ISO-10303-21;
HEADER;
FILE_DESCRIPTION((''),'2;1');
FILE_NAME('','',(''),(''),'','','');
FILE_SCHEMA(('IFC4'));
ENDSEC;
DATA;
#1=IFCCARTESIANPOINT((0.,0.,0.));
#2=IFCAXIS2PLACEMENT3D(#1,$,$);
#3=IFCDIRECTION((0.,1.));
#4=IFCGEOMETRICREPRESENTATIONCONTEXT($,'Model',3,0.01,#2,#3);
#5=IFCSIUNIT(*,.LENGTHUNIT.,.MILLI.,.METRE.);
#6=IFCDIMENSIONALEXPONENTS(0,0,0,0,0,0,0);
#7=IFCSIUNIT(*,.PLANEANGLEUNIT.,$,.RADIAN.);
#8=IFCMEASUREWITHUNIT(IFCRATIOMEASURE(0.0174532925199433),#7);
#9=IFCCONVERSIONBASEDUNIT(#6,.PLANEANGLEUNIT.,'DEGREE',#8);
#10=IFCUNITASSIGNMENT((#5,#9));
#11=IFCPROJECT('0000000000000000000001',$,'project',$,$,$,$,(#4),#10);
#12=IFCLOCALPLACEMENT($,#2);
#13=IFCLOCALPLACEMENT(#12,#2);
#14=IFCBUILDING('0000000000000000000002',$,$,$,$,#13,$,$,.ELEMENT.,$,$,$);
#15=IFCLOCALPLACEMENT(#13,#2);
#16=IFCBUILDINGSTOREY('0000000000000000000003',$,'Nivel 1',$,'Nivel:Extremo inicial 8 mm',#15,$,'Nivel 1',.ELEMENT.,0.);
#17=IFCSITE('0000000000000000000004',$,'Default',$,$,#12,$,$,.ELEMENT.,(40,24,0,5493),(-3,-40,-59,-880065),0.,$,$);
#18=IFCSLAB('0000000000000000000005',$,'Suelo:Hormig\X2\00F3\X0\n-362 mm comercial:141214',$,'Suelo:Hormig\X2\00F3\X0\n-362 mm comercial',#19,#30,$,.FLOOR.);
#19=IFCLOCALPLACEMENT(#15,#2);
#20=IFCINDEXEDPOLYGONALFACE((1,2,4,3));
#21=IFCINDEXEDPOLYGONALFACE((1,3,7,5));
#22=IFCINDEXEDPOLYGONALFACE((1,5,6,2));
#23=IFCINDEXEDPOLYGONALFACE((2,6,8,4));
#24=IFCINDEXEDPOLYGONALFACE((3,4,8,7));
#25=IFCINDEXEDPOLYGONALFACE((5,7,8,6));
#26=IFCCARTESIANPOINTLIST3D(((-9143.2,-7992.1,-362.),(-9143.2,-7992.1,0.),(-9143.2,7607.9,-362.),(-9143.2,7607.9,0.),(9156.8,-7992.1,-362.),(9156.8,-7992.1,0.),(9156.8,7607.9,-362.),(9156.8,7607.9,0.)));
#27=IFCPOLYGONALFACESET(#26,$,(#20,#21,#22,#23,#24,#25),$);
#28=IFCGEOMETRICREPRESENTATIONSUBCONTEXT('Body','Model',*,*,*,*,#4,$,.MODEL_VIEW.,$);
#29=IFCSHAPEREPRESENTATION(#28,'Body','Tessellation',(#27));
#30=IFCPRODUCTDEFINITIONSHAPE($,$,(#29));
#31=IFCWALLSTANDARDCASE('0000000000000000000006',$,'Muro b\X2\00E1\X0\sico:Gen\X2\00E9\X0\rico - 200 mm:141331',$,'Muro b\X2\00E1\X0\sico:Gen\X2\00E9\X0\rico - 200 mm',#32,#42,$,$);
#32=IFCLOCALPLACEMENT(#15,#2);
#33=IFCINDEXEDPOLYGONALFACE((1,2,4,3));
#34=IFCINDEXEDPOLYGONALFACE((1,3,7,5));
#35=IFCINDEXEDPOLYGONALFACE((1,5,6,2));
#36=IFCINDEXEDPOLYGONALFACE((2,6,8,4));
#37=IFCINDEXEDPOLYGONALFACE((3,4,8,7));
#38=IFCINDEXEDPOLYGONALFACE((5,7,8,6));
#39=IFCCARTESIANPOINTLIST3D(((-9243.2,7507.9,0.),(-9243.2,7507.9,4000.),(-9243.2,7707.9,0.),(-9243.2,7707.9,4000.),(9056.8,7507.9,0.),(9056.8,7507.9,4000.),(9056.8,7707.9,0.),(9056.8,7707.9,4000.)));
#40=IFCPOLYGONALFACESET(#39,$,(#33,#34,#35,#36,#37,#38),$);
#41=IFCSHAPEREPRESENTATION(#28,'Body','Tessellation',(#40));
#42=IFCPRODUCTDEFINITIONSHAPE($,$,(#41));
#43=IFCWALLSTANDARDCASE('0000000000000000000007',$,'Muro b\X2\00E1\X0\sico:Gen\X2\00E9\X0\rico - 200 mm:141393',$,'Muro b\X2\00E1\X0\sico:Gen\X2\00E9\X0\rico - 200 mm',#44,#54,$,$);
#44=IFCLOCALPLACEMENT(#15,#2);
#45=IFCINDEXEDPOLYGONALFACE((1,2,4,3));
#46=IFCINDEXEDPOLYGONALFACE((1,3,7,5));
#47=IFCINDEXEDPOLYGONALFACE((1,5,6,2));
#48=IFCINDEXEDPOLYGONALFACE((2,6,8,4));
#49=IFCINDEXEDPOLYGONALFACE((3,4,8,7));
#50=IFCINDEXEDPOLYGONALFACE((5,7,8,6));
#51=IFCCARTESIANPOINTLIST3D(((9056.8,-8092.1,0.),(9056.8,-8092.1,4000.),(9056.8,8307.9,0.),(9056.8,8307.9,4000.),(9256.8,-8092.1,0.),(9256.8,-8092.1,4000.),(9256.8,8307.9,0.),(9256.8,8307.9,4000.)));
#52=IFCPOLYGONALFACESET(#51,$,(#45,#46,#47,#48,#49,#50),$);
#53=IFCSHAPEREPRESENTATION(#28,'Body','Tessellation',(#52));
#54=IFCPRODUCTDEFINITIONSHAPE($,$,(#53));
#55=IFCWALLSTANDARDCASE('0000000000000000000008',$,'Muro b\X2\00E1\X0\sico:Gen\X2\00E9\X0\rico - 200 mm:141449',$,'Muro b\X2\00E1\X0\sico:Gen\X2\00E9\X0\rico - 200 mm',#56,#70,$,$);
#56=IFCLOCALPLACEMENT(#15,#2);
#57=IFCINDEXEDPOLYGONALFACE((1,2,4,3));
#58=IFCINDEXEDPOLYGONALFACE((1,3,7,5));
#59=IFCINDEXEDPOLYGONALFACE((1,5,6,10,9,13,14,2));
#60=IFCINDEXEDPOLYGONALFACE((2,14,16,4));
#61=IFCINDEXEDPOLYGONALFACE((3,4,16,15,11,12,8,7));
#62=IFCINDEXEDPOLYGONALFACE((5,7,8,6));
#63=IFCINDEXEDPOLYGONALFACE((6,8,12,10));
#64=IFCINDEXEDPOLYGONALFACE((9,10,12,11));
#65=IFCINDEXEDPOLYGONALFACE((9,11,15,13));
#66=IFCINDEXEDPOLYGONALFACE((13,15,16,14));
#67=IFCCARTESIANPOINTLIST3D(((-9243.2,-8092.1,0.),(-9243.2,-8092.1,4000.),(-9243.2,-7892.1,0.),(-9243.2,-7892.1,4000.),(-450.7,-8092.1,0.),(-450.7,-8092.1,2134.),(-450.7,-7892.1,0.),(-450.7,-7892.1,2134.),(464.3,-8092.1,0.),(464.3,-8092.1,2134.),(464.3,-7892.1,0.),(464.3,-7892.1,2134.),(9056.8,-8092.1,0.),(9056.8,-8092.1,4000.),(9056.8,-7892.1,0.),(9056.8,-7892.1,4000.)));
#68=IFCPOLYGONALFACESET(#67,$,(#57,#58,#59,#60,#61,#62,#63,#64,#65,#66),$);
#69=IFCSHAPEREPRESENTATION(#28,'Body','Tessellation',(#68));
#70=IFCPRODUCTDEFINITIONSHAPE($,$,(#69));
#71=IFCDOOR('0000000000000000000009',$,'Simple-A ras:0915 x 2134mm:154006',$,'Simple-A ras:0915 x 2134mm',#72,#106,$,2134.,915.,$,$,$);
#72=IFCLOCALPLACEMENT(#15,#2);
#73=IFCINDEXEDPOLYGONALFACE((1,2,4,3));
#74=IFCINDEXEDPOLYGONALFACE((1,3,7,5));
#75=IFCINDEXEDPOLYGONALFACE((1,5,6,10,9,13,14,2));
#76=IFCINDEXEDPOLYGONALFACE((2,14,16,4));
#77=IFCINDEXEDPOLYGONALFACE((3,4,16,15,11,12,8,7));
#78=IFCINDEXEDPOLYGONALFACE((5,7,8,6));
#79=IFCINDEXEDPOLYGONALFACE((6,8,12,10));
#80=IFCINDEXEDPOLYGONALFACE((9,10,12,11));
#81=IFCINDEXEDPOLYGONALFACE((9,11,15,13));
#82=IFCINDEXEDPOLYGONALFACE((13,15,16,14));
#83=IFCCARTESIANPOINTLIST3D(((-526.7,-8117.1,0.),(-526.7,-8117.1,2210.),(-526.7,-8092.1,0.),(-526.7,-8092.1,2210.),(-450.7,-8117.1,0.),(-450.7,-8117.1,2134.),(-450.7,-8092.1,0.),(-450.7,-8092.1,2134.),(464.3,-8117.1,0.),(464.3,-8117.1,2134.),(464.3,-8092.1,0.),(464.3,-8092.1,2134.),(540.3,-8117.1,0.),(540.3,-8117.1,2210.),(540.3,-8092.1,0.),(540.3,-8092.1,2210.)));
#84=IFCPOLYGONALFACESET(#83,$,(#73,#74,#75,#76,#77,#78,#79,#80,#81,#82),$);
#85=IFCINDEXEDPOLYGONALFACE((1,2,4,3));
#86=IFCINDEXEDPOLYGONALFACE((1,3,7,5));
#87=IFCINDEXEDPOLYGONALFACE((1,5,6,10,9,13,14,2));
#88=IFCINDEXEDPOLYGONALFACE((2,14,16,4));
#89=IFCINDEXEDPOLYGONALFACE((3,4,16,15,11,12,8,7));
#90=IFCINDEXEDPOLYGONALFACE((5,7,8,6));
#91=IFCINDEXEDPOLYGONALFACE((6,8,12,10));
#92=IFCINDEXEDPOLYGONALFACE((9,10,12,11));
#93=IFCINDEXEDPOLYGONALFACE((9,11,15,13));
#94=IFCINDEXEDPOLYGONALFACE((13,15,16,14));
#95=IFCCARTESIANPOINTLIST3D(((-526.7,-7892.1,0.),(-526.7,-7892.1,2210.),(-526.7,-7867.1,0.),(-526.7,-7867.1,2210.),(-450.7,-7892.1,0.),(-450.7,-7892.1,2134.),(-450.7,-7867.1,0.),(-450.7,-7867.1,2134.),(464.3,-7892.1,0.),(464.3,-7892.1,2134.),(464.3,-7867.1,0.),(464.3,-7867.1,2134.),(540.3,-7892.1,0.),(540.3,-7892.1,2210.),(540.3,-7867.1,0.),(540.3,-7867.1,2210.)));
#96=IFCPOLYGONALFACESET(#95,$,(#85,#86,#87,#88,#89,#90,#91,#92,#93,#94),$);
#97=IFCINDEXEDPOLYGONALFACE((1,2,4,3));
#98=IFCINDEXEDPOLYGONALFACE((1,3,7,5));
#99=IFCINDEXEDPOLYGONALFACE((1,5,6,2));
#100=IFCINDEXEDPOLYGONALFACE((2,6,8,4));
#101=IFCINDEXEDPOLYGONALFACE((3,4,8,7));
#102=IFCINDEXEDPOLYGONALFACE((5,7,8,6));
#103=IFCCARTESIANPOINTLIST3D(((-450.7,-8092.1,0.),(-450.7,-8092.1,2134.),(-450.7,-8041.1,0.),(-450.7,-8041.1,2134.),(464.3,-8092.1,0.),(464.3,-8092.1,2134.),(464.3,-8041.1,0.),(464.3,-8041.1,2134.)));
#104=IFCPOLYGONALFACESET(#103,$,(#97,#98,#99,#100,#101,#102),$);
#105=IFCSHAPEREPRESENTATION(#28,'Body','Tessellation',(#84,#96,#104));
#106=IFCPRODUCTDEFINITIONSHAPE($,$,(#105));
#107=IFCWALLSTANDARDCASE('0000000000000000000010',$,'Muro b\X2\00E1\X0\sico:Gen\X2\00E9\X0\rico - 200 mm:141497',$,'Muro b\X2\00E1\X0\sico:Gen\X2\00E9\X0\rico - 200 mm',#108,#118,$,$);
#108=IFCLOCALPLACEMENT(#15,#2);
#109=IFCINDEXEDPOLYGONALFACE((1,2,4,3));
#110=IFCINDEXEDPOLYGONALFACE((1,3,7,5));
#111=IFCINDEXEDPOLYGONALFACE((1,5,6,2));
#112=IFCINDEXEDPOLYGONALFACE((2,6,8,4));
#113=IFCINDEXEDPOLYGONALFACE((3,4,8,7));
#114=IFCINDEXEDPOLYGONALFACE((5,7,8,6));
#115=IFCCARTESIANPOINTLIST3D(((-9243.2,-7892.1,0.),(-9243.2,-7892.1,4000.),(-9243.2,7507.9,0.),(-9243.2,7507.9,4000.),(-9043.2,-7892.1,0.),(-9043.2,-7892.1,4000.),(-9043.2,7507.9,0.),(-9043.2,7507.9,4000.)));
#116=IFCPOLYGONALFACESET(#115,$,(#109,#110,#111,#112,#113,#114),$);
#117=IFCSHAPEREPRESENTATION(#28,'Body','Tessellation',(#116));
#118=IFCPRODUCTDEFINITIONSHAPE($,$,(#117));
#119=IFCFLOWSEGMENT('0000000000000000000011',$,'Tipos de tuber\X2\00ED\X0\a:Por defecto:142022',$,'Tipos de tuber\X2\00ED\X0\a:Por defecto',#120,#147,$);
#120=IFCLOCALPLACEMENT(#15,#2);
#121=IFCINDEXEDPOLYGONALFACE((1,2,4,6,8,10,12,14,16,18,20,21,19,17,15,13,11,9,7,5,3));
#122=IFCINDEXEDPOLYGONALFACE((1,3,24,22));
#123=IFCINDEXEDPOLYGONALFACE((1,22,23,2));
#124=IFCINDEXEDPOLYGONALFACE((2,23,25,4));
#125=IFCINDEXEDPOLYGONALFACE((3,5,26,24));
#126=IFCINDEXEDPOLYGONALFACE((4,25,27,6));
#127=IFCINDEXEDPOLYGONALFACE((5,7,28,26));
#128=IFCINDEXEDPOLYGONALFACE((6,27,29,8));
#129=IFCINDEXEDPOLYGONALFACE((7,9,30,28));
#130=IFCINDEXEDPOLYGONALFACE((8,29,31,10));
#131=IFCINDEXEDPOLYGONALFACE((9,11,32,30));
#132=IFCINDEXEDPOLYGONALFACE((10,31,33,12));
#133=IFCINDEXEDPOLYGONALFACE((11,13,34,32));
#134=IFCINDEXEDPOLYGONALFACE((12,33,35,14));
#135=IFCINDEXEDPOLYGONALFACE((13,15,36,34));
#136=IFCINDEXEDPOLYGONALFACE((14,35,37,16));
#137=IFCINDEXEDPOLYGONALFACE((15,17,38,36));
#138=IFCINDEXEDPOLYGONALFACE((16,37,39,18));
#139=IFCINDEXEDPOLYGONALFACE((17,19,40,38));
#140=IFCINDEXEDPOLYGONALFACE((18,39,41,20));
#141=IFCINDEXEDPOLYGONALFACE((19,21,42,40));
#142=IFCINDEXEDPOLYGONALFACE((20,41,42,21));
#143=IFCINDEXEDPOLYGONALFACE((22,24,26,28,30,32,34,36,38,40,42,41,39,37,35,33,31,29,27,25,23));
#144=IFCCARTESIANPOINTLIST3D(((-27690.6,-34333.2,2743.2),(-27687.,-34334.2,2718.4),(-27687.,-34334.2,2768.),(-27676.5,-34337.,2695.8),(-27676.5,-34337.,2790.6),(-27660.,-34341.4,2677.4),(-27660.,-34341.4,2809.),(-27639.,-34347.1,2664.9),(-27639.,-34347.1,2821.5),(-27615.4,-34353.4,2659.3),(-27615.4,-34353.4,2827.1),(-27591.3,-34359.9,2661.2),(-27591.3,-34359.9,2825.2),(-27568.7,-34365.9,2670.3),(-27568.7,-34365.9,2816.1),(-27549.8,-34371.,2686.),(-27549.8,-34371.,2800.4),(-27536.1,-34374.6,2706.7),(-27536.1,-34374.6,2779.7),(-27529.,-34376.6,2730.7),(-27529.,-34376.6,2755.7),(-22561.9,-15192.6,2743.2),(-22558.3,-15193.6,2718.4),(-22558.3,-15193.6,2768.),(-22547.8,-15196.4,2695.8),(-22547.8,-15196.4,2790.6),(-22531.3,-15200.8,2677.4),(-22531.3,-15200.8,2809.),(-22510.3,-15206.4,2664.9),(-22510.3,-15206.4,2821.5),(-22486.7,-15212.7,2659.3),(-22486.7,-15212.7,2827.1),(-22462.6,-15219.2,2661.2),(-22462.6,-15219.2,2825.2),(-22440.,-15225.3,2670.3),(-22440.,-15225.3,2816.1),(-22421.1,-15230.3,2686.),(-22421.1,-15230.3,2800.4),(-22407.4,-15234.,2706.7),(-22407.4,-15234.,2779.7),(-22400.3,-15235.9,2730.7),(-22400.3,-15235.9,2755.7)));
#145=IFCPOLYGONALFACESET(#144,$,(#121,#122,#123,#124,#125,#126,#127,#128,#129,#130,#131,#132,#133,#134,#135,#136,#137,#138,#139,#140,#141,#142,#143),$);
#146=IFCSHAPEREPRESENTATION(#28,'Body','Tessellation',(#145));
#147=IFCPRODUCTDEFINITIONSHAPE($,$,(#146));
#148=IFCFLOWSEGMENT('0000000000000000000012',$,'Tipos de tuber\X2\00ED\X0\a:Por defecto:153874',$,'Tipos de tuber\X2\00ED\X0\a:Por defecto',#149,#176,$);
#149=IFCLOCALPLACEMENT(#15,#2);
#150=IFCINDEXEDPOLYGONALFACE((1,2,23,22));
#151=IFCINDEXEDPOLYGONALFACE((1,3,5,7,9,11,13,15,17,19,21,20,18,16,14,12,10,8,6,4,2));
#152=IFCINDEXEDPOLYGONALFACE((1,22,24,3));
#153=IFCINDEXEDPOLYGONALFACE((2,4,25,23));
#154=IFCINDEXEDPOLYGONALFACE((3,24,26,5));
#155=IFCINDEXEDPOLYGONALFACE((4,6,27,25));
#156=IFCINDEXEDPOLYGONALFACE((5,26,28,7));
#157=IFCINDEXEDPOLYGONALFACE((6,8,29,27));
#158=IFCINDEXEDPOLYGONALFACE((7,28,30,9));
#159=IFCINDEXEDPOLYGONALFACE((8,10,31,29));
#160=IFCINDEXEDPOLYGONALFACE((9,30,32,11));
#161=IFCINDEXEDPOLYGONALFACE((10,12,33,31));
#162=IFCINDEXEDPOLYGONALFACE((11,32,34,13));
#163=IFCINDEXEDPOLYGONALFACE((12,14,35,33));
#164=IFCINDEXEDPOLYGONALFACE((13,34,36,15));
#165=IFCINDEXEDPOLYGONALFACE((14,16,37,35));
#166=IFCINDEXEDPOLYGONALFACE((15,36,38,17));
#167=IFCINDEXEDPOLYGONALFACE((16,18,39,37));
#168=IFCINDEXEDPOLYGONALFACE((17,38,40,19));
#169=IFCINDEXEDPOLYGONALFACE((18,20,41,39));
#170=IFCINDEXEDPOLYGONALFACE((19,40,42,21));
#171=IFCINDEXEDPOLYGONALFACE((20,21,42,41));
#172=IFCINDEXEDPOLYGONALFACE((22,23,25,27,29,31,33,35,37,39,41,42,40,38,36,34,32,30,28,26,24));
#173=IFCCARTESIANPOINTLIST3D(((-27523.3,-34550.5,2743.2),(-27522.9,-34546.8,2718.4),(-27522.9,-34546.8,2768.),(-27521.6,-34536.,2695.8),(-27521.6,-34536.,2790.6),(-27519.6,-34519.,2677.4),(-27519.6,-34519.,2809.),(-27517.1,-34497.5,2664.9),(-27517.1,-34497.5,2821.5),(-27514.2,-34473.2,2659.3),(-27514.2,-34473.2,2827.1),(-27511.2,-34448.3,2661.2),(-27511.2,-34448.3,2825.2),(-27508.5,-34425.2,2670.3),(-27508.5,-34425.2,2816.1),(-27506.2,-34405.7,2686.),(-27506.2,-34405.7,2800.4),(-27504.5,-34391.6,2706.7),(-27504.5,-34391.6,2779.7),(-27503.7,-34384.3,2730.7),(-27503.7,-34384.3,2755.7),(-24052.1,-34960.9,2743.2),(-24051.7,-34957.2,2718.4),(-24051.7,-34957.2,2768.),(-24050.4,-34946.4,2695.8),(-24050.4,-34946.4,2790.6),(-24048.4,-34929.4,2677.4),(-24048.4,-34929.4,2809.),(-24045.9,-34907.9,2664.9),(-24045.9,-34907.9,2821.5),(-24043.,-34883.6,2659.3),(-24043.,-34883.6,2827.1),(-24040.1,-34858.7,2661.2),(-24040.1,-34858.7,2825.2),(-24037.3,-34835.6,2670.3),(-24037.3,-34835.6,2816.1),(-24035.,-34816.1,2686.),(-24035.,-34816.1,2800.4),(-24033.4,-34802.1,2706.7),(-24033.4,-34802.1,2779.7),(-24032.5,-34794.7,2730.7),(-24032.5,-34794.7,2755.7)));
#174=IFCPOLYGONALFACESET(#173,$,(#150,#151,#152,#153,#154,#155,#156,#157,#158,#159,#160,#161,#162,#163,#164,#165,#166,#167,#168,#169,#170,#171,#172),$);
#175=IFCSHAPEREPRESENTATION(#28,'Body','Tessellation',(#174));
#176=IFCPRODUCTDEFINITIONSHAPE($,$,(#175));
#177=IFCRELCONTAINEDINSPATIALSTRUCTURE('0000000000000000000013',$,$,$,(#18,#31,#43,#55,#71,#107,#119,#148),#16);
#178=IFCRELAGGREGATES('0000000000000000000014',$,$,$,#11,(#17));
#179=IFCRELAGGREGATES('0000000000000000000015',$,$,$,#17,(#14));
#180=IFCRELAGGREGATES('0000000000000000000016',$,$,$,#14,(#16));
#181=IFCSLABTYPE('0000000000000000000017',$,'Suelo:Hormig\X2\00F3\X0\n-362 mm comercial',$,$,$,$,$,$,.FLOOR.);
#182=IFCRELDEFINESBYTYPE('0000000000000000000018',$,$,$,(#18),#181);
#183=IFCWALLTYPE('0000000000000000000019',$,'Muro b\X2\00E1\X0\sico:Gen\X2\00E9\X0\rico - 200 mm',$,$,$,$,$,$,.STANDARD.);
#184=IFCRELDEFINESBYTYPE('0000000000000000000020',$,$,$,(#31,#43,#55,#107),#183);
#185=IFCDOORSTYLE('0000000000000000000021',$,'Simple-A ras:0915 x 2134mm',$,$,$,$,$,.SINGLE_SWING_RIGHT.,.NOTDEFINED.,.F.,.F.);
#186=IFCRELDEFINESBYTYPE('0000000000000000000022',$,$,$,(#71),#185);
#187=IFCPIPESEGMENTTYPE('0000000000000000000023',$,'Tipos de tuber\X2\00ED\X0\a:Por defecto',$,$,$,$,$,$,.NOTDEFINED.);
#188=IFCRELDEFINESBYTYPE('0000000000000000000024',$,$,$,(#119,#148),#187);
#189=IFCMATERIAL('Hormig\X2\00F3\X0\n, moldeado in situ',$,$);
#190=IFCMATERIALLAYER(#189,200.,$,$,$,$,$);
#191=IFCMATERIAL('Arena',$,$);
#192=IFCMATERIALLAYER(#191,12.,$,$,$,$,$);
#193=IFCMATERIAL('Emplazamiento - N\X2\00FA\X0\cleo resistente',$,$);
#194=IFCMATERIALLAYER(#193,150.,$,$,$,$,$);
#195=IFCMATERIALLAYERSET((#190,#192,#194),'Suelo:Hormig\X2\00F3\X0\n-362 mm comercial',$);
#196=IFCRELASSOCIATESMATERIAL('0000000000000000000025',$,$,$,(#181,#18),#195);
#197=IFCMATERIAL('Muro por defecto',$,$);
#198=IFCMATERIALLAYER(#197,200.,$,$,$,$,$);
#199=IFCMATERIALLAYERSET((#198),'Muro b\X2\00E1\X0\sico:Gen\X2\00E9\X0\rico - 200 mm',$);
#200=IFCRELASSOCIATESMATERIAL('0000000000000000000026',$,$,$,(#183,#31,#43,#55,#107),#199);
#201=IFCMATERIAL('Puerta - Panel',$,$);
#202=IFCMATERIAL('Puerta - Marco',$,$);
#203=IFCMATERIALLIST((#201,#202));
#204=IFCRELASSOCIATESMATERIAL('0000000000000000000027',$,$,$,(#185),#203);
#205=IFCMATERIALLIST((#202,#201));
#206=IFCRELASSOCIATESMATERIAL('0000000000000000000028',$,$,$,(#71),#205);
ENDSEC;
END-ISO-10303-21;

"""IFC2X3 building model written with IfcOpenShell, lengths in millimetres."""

from ifc_helpers import new_model, entity, si_unit, converted_unit, direction, frame, frame_2d, origin, origin_2d_with_axis, place, context, subcontext, project, spatial, polyline, rectangle, circle, outline, extrude, source, transform, mapped, material, material_list, layer, layer_set, layer_usage, type_object, type_shapes, element, fill, save


model = new_model("IFC2X3")

# Units and contexts
model_context = context("Model", 3, precision=0.01, world=origin(), true_north=direction((0.0, 1.0)))
body_context = subcontext(model_context, "Body", "Model", "MODEL_VIEW")
ifc_project = project(units=[si_unit("LENGTHUNIT", "METRE", prefix="MILLI"), converted_unit("PLANEANGLEUNIT", "DEGREE", entity("IfcRatioMeasure", 0.0174532925199433), si_unit("PLANEANGLEUNIT", "RADIAN"), dimensions=[0, 0, 0, 0, 0, 0, 0])], contexts=[model_context])

# Site, building, storey
site_placement = place(None, origin())
site = spatial("IfcSite", under=ifc_project, at=site_placement, Name="Default", CompositionType="ELEMENT", RefLatitude=(40, 24, 0, 5493), RefLongitude=(-3, -40, -59, -880065), RefElevation=0.0)
building_placement = place(site_placement, origin())
building = spatial("IfcBuilding", under=site, at=building_placement, CompositionType="ELEMENT")
storey_placement = place(building_placement, origin())
storey = spatial("IfcBuildingStorey", under=building, at=storey_placement, Name="Nivel 1", ObjectType="Nivel:Extremo inicial 8 mm", LongName="Nivel 1", CompositionType="ELEMENT", Elevation=0.0)

# Slab
ifc_material_1 = material(Name="Hormigón, moldeado in situ")
ifc_layer_1 = layer(ifc_material_1, 200.0)
ifc_material_2 = material(Name="Arena")
ifc_layer_2 = layer(ifc_material_2, 12.0)
ifc_material_3 = material(Name="Emplazamiento - Núcleo resistente")
ifc_layer_3 = layer(ifc_material_3, 150.0)
ifc_layer_set_1 = layer_set([ifc_layer_1, ifc_layer_2, ifc_layer_3], Name="Suelo:Hormigón-362 mm comercial")
ifc_layer_usage_1 = layer_usage(ifc_layer_set_1, "AXIS3", "POSITIVE", 0.0)
slab_type = type_object("IfcSlabType", Name="Suelo:Hormigón-362 mm comercial", PredefinedType="FLOOR", material=ifc_layer_set_1)
slab_placement = place(storey_placement, origin())
element("IfcSlab", 1, at=slab_placement, inside=storey, type_object=slab_type, material=ifc_layer_usage_1, Name="Suelo:Hormigón-362 mm comercial:141214", ObjectType="Suelo:Hormigón-362 mm comercial", PredefinedType="FLOOR", context=body_context, shape_type="SweptSolid", body=[
    extrude(rectangle(XDim=15600.0, YDim=18300.0, at=origin_2d_with_axis()), frame((6.8, -192.1, 0.0), z_axis=(0.0, 0.0, -1.0), x_axis=(0.0, 1.0, 0.0)), (0.0, 0.0, 1.0), 362.0),
])

# Walls
ifc_material_4 = material(Name="Muro por defecto")
ifc_layer_4 = layer(ifc_material_4, 200.0)
ifc_layer_set_2 = layer_set([ifc_layer_4], Name="Muro básico:Genérico - 200 mm")
ifc_layer_usage_2 = layer_usage(ifc_layer_set_2, "AXIS2", "NEGATIVE", 100.0)
wall_type = type_object("IfcWallType", Name="Muro básico:Genérico - 200 mm", PredefinedType="STANDARD", material=ifc_layer_set_2)
wall_1_placement = place(storey_placement, frame((-9243.2, 7607.9, 0.0)))
element("IfcWallStandardCase", 2, at=wall_1_placement, inside=storey, type_object=wall_type, material=ifc_layer_usage_2, Name="Muro básico:Genérico - 200 mm:141331", ObjectType="Muro básico:Genérico - 200 mm", context=body_context, shape_type="SweptSolid", body=[
    extrude(rectangle(XDim=18300.0, YDim=200.0, at=frame_2d((9150.0, 0.0), x_axis=(-1.0, 0.0))), origin(), (0.0, 0.0, 1.0), 4000.0),
])
ifc_layer_usage_3 = layer_usage(ifc_layer_set_2, "AXIS2", "NEGATIVE", 100.0)
wall_2_placement = place(storey_placement, frame((9156.8, 8307.9, 0.0), z_axis=(0.0, 0.0, 1.0), x_axis=(0.0, -1.0, 0.0)))
element("IfcWallStandardCase", 3, at=wall_2_placement, inside=storey, type_object=wall_type, material=ifc_layer_usage_3, Name="Muro básico:Genérico - 200 mm:141393", ObjectType="Muro básico:Genérico - 200 mm", context=body_context, shape_type="SweptSolid", body=[
    extrude(rectangle(XDim=16400.0, YDim=200.0, at=frame_2d((8200.0, 0.0), x_axis=(-1.0, 0.0))), origin(), (0.0, 0.0, 1.0), 4000.0),
])

# Wall, opening, door
ifc_layer_usage_4 = layer_usage(ifc_layer_set_2, "AXIS2", "NEGATIVE", 100.0)
wall_3_placement = place(storey_placement, frame((9056.8, -7992.1, 0.0), z_axis=(0.0, 0.0, 1.0), x_axis=(-1.0, 0.0, 0.0)))
wall_3 = element("IfcWallStandardCase", 4, at=wall_3_placement, inside=storey, type_object=wall_type, material=ifc_layer_usage_4, Name="Muro básico:Genérico - 200 mm:141449", ObjectType="Muro básico:Genérico - 200 mm", context=body_context, shape_type="SweptSolid", body=[
    extrude(rectangle(XDim=18300.0, YDim=200.0, at=frame_2d((9150.0, 0.0), x_axis=(-1.0, 0.0))), origin(), (0.0, 0.0, 1.0), 4000.0),
])
opening_placement = place(wall_3_placement, frame((8592.5, -100.0, 0.0)))
opening = element("IfcOpeningElement", 5, at=opening_placement, cuts=wall_3, ObjectType="Opening", context=body_context, shape_type="SweptSolid", body=[
    extrude(rectangle(XDim=915.0, YDim=2134.0, at=frame_2d((1067.0, 457.5), x_axis=(0.0, 1.0))), frame((0.0, 0.0, 0.0), z_axis=(0.0, 1.0, 0.0), x_axis=(0.0, 0.0, 1.0)), (0.0, 0.0, 1.0), 200.0),
])
ifc_material_5 = material(Name="Puerta - Marco")
ifc_material_6 = material(Name="Puerta - Panel")
ifc_material_list_1 = material_list([ifc_material_5, ifc_material_6])
ifc_material_list_2 = material_list([ifc_material_6, ifc_material_5])
door_style = type_object("IfcDoorStyle", Name="Simple-A ras:0915 x 2134mm", ConstructionType="NOTDEFINED", OperationType="SINGLE_SWING_RIGHT", ParameterTakesPrecedence=False, Sizeable=False, material=ifc_material_list_2)
shared_shape = source(origin(), body_context, "Body", "SweptSolid", [
    extrude(outline(polyline([(-533.5, -1124.0), (533.5, -1124.0), (533.5, 1086.0), (457.5, 1086.0), (457.5, -1048.0), (-457.5, -1048.0), (-457.5, 1086.0), (-533.5, 1086.0), (-533.5, -1124.0)])), frame((457.5, 200.0, 1086.0), z_axis=(0.0, 1.0, 0.0), x_axis=(1.0, 0.0, 0.0)), (0.0, 0.0, 1.0), 25.0),
    extrude(outline(polyline([(-1124.0, -533.5), (1086.0, -533.5), (1086.0, -457.5), (-1048.0, -457.5), (-1048.0, 457.5), (1086.0, 457.5), (1086.0, 533.5), (-1124.0, 533.5), (-1124.0, -533.5)])), frame((457.5, -25.0, 1086.0), z_axis=(0.0, 1.0, 0.0), x_axis=(0.0, 0.0, -1.0)), (0.0, 0.0, 1.0), 25.0),
    extrude(rectangle(XDim=51.0, YDim=915.0, at=frame_2d((0.0, 0.0), x_axis=(1.0, 0.0))), frame((457.5, 174.5, 0.0), z_axis=(0.0, 0.0, 1.0), x_axis=(0.0, 1.0, 0.0)), (0.0, 0.0, 1.0), 2134.0),
])
type_shapes(door_style, [shared_shape])
door_placement = place(opening_placement, origin())
door = element("IfcDoor", 6, at=door_placement, inside=storey, type_object=door_style, material=ifc_material_list_1, Name="Simple-A ras:0915 x 2134mm:154006", ObjectType="Simple-A ras:0915 x 2134mm", OverallHeight=2134.0, OverallWidth=915.0, context=body_context, shape_type="MappedRepresentation", body=[
    mapped(shared_shape, transform((0.0, 0.0, 0.0), scale=1.0)),
])
fill(opening, door)

# Wall
ifc_layer_usage_5 = layer_usage(ifc_layer_set_2, "AXIS2", "NEGATIVE", 100.0)
wall_4_placement = place(storey_placement, frame((-9143.2, -7892.1, 0.0), z_axis=(0.0, 0.0, 1.0), x_axis=(0.0, 1.0, 0.0)))
element("IfcWallStandardCase", 7, at=wall_4_placement, inside=storey, type_object=wall_type, material=ifc_layer_usage_5, Name="Muro básico:Genérico - 200 mm:141497", ObjectType="Muro básico:Genérico - 200 mm", context=body_context, shape_type="SweptSolid", body=[
    extrude(rectangle(XDim=15400.0, YDim=200.0, at=frame_2d((7700.0, 0.0), x_axis=(-1.0, 0.0))), origin(), (0.0, 0.0, 1.0), 4000.0),
])

# Flow segments
pipe_segment_type = type_object("IfcPipeSegmentType", Name="Tipos de tubería:Por defecto", PredefinedType="NOTDEFINED")
flow_segment_1_placement = place(storey_placement, origin())
element("IfcFlowSegment", 8, at=flow_segment_1_placement, inside=storey, type_object=pipe_segment_type, Name="Tipos de tubería:Por defecto:142022", ObjectType="Tipos de tubería:Por defecto", context=body_context, shape_type="SweptSolid", body=[
    extrude(circle(Radius=84.1, at=frame_2d((0.0, 0.0), x_axis=(1.0, 0.0))), frame((-27609.4, -34355.0, 2743.2), z_axis=(0.258819, 0.965926, 0.0), x_axis=(-0.965926, 0.258819, 0.0)), (0.0, 0.0, 1.0), 19815.9),
])
flow_segment_2_placement = place(storey_placement, origin())
element("IfcFlowSegment", 9, at=flow_segment_2_placement, inside=storey, type_object=pipe_segment_type, Name="Tipos de tubería:Por defecto:153874", ObjectType="Tipos de tubería:Por defecto", context=body_context, shape_type="SweptSolid", body=[
    extrude(circle(Radius=84.1, at=frame_2d((0.0, 0.0), x_axis=(1.0, 0.0))), frame((-24042.3, -34877.3, 2743.2), z_axis=(-0.993083, 0.117415, 0.0), x_axis=(-0.117415, -0.993083, 0.0)), (0.0, 0.0, 1.0), 3495.4),
])

save(model, "model.ifc")
